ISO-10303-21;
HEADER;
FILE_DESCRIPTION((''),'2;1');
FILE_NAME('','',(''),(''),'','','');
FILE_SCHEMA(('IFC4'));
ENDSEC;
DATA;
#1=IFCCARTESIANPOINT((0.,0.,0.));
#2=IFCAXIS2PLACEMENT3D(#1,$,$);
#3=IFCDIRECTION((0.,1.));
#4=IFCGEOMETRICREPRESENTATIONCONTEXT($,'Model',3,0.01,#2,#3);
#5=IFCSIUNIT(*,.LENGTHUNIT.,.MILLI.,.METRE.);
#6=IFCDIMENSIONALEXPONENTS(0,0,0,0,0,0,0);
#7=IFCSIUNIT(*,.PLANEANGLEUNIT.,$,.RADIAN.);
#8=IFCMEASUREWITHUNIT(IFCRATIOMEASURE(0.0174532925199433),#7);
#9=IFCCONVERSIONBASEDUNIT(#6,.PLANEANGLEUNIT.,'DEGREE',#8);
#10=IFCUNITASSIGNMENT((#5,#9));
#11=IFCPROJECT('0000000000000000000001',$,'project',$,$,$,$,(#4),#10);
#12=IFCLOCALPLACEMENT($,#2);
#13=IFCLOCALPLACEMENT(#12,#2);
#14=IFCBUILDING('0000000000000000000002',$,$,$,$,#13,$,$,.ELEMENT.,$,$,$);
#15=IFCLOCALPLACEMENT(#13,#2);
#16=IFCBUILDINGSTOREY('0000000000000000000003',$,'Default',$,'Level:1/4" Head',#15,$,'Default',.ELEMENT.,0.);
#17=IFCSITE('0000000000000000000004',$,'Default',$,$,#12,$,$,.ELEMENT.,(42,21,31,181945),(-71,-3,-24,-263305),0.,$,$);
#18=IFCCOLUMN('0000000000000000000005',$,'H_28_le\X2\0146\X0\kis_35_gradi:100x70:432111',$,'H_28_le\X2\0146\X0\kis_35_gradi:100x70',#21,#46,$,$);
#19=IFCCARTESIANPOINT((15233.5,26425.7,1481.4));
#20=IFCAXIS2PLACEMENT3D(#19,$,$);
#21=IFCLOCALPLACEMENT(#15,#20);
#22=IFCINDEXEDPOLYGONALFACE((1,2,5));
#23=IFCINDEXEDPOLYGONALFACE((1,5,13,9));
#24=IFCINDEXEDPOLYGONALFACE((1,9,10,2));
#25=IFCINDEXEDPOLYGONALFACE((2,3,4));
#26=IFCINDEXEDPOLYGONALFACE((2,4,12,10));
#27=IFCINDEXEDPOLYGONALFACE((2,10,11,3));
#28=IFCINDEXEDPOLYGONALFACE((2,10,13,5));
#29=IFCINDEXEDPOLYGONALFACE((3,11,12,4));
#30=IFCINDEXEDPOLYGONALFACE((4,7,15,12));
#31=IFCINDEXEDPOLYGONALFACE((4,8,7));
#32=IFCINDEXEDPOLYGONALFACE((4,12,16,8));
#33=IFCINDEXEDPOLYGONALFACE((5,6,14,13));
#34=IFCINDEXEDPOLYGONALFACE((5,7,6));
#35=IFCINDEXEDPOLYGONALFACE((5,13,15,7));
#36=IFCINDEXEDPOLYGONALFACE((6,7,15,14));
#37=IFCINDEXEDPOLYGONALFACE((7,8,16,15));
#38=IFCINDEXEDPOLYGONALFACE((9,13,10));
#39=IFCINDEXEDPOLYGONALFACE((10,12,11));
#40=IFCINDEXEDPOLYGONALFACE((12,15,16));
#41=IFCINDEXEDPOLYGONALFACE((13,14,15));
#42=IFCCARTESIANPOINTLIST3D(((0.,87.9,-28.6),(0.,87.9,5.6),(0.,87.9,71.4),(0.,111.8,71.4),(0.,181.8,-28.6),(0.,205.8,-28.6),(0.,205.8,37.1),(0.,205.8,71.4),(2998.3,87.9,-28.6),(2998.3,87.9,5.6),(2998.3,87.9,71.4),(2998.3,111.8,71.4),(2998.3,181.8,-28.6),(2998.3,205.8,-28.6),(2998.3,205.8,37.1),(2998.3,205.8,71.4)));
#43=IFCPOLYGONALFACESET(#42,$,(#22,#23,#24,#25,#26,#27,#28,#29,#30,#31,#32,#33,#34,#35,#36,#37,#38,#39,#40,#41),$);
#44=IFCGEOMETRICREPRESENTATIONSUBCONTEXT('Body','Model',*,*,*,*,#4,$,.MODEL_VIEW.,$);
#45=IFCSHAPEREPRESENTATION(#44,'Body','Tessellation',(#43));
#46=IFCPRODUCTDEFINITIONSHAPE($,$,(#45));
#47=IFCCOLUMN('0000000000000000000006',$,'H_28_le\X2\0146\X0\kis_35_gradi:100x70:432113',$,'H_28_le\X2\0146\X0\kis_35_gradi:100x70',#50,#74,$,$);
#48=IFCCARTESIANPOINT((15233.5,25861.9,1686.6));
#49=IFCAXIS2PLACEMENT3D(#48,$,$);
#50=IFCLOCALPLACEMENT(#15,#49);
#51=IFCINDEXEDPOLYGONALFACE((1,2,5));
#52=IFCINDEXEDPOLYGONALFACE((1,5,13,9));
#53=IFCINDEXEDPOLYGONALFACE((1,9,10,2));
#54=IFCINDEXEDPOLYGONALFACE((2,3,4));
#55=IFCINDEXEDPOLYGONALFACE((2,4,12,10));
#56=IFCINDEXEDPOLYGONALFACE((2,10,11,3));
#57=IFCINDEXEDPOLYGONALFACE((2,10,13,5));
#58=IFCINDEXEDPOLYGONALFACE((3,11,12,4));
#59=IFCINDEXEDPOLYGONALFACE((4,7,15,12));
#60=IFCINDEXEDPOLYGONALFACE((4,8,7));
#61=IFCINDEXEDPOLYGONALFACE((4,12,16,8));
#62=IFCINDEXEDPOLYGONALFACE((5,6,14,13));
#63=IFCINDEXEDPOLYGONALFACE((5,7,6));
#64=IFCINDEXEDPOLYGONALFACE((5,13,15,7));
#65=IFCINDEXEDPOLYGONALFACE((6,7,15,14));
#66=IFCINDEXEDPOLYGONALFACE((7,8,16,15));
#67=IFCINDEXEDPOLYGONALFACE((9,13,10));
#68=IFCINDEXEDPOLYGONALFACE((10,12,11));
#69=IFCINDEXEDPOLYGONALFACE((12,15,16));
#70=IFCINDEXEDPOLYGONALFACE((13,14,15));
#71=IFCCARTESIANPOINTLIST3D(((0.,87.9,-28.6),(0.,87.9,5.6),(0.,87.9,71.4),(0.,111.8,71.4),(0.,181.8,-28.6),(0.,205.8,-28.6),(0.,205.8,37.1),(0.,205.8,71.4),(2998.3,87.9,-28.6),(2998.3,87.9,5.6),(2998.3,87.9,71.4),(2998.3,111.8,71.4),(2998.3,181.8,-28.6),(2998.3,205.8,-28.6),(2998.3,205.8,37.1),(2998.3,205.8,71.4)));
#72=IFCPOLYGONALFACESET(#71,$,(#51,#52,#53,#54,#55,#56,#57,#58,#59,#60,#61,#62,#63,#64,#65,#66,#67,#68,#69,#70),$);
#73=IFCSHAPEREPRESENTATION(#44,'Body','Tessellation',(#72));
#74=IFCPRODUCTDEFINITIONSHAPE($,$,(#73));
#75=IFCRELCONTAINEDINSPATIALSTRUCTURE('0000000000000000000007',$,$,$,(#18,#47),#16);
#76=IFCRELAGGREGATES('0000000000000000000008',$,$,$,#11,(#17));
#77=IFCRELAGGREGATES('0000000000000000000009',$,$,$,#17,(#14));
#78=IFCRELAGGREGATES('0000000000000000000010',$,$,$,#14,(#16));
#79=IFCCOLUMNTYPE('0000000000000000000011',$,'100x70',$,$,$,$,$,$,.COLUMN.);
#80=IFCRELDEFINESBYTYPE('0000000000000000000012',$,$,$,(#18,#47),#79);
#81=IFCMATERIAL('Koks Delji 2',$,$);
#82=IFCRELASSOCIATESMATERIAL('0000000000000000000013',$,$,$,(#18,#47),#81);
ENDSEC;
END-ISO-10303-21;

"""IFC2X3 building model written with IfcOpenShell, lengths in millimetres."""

from ifc_helpers import new_model, entity, si_unit, converted_unit, direction, frame, frame_2d, origin, place, context, subcontext, project, spatial, rectangle, extrude, boolean, source, transform, mapped, material, type_object, type_shapes, element, save


model = new_model("IFC2X3")

# Units and contexts
model_context = context("Model", 3, precision=0.01, world=origin(), true_north=direction((0.0, 1.0)))
body_context = subcontext(model_context, "Body", "Model", "MODEL_VIEW")
ifc_project = project(units=[si_unit("LENGTHUNIT", "METRE", prefix="MILLI"), converted_unit("PLANEANGLEUNIT", "DEGREE", entity("IfcRatioMeasure", 0.0174532925199433), si_unit("PLANEANGLEUNIT", "RADIAN"), dimensions=[0, 0, 0, 0, 0, 0, 0])], contexts=[model_context])

# Site, building, storey
site_placement = place(None, origin())
site = spatial("IfcSite", under=ifc_project, at=site_placement, Name="Default", CompositionType="ELEMENT", RefLatitude=(42, 21, 31, 181945), RefLongitude=(-71, -3, -24, -263305), RefElevation=0.0)
building_placement = place(site_placement, origin())
building = spatial("IfcBuilding", under=site, at=building_placement, CompositionType="ELEMENT")
storey_placement = place(building_placement, origin())
storey = spatial("IfcBuildingStorey", under=building, at=storey_placement, Name="Default", ObjectType="Level:1/4\" Head", LongName="Default", CompositionType="ELEMENT", Elevation=0.0)

# Columns
ifc_material_1 = material(Name="Koks Delji 2")
column_type = type_object("IfcColumnType", Name="100x70", PredefinedType="COLUMN")
shared_shape_1 = source(origin(), body_context, "Body", "CSG", [
    boolean("DIFFERENCE", extrude(rectangle(XDim=2998.3, YDim=117.9, at=frame_2d((0.0, 0.0), x_axis=(1.0, 0.0))), frame((1499.1, 146.8, -28.6)), (0.0, 0.0, 1.0), 100.0), extrude(rectangle(XDim=70.0, YDim=100.0, at=frame_2d((0.0, 0.0), x_axis=(0.0, 1.0))), frame((2998.3, 146.8, 21.4), z_axis=(1.0, 0.0, 0.0), x_axis=(0.0, 0.939693, -0.34202)), (0.0, 0.0, -1.0), 2998.3)),
])
type_shapes(column_type, [shared_shape_1])
for number, where, name in (
    (1, (15233.5, 26425.7, 1481.4), "H_28_leņkis_35_gradi:100x70:432111"),
    (2, (15233.5, 25861.9, 1686.6), "H_28_leņkis_35_gradi:100x70:432113"),
):
    element("IfcColumn", number, at=place(storey_placement, frame(where)), inside=storey, type_object=column_type, material=ifc_material_1, Name=name, ObjectType="H_28_leņkis_35_gradi:100x70", context=body_context, shape_type="MappedRepresentation", body=[
        mapped(shared_shape_1, transform((0.0, 0.0, 0.0), scale=1.0)),
    ])

save(model, "model.ifc")
